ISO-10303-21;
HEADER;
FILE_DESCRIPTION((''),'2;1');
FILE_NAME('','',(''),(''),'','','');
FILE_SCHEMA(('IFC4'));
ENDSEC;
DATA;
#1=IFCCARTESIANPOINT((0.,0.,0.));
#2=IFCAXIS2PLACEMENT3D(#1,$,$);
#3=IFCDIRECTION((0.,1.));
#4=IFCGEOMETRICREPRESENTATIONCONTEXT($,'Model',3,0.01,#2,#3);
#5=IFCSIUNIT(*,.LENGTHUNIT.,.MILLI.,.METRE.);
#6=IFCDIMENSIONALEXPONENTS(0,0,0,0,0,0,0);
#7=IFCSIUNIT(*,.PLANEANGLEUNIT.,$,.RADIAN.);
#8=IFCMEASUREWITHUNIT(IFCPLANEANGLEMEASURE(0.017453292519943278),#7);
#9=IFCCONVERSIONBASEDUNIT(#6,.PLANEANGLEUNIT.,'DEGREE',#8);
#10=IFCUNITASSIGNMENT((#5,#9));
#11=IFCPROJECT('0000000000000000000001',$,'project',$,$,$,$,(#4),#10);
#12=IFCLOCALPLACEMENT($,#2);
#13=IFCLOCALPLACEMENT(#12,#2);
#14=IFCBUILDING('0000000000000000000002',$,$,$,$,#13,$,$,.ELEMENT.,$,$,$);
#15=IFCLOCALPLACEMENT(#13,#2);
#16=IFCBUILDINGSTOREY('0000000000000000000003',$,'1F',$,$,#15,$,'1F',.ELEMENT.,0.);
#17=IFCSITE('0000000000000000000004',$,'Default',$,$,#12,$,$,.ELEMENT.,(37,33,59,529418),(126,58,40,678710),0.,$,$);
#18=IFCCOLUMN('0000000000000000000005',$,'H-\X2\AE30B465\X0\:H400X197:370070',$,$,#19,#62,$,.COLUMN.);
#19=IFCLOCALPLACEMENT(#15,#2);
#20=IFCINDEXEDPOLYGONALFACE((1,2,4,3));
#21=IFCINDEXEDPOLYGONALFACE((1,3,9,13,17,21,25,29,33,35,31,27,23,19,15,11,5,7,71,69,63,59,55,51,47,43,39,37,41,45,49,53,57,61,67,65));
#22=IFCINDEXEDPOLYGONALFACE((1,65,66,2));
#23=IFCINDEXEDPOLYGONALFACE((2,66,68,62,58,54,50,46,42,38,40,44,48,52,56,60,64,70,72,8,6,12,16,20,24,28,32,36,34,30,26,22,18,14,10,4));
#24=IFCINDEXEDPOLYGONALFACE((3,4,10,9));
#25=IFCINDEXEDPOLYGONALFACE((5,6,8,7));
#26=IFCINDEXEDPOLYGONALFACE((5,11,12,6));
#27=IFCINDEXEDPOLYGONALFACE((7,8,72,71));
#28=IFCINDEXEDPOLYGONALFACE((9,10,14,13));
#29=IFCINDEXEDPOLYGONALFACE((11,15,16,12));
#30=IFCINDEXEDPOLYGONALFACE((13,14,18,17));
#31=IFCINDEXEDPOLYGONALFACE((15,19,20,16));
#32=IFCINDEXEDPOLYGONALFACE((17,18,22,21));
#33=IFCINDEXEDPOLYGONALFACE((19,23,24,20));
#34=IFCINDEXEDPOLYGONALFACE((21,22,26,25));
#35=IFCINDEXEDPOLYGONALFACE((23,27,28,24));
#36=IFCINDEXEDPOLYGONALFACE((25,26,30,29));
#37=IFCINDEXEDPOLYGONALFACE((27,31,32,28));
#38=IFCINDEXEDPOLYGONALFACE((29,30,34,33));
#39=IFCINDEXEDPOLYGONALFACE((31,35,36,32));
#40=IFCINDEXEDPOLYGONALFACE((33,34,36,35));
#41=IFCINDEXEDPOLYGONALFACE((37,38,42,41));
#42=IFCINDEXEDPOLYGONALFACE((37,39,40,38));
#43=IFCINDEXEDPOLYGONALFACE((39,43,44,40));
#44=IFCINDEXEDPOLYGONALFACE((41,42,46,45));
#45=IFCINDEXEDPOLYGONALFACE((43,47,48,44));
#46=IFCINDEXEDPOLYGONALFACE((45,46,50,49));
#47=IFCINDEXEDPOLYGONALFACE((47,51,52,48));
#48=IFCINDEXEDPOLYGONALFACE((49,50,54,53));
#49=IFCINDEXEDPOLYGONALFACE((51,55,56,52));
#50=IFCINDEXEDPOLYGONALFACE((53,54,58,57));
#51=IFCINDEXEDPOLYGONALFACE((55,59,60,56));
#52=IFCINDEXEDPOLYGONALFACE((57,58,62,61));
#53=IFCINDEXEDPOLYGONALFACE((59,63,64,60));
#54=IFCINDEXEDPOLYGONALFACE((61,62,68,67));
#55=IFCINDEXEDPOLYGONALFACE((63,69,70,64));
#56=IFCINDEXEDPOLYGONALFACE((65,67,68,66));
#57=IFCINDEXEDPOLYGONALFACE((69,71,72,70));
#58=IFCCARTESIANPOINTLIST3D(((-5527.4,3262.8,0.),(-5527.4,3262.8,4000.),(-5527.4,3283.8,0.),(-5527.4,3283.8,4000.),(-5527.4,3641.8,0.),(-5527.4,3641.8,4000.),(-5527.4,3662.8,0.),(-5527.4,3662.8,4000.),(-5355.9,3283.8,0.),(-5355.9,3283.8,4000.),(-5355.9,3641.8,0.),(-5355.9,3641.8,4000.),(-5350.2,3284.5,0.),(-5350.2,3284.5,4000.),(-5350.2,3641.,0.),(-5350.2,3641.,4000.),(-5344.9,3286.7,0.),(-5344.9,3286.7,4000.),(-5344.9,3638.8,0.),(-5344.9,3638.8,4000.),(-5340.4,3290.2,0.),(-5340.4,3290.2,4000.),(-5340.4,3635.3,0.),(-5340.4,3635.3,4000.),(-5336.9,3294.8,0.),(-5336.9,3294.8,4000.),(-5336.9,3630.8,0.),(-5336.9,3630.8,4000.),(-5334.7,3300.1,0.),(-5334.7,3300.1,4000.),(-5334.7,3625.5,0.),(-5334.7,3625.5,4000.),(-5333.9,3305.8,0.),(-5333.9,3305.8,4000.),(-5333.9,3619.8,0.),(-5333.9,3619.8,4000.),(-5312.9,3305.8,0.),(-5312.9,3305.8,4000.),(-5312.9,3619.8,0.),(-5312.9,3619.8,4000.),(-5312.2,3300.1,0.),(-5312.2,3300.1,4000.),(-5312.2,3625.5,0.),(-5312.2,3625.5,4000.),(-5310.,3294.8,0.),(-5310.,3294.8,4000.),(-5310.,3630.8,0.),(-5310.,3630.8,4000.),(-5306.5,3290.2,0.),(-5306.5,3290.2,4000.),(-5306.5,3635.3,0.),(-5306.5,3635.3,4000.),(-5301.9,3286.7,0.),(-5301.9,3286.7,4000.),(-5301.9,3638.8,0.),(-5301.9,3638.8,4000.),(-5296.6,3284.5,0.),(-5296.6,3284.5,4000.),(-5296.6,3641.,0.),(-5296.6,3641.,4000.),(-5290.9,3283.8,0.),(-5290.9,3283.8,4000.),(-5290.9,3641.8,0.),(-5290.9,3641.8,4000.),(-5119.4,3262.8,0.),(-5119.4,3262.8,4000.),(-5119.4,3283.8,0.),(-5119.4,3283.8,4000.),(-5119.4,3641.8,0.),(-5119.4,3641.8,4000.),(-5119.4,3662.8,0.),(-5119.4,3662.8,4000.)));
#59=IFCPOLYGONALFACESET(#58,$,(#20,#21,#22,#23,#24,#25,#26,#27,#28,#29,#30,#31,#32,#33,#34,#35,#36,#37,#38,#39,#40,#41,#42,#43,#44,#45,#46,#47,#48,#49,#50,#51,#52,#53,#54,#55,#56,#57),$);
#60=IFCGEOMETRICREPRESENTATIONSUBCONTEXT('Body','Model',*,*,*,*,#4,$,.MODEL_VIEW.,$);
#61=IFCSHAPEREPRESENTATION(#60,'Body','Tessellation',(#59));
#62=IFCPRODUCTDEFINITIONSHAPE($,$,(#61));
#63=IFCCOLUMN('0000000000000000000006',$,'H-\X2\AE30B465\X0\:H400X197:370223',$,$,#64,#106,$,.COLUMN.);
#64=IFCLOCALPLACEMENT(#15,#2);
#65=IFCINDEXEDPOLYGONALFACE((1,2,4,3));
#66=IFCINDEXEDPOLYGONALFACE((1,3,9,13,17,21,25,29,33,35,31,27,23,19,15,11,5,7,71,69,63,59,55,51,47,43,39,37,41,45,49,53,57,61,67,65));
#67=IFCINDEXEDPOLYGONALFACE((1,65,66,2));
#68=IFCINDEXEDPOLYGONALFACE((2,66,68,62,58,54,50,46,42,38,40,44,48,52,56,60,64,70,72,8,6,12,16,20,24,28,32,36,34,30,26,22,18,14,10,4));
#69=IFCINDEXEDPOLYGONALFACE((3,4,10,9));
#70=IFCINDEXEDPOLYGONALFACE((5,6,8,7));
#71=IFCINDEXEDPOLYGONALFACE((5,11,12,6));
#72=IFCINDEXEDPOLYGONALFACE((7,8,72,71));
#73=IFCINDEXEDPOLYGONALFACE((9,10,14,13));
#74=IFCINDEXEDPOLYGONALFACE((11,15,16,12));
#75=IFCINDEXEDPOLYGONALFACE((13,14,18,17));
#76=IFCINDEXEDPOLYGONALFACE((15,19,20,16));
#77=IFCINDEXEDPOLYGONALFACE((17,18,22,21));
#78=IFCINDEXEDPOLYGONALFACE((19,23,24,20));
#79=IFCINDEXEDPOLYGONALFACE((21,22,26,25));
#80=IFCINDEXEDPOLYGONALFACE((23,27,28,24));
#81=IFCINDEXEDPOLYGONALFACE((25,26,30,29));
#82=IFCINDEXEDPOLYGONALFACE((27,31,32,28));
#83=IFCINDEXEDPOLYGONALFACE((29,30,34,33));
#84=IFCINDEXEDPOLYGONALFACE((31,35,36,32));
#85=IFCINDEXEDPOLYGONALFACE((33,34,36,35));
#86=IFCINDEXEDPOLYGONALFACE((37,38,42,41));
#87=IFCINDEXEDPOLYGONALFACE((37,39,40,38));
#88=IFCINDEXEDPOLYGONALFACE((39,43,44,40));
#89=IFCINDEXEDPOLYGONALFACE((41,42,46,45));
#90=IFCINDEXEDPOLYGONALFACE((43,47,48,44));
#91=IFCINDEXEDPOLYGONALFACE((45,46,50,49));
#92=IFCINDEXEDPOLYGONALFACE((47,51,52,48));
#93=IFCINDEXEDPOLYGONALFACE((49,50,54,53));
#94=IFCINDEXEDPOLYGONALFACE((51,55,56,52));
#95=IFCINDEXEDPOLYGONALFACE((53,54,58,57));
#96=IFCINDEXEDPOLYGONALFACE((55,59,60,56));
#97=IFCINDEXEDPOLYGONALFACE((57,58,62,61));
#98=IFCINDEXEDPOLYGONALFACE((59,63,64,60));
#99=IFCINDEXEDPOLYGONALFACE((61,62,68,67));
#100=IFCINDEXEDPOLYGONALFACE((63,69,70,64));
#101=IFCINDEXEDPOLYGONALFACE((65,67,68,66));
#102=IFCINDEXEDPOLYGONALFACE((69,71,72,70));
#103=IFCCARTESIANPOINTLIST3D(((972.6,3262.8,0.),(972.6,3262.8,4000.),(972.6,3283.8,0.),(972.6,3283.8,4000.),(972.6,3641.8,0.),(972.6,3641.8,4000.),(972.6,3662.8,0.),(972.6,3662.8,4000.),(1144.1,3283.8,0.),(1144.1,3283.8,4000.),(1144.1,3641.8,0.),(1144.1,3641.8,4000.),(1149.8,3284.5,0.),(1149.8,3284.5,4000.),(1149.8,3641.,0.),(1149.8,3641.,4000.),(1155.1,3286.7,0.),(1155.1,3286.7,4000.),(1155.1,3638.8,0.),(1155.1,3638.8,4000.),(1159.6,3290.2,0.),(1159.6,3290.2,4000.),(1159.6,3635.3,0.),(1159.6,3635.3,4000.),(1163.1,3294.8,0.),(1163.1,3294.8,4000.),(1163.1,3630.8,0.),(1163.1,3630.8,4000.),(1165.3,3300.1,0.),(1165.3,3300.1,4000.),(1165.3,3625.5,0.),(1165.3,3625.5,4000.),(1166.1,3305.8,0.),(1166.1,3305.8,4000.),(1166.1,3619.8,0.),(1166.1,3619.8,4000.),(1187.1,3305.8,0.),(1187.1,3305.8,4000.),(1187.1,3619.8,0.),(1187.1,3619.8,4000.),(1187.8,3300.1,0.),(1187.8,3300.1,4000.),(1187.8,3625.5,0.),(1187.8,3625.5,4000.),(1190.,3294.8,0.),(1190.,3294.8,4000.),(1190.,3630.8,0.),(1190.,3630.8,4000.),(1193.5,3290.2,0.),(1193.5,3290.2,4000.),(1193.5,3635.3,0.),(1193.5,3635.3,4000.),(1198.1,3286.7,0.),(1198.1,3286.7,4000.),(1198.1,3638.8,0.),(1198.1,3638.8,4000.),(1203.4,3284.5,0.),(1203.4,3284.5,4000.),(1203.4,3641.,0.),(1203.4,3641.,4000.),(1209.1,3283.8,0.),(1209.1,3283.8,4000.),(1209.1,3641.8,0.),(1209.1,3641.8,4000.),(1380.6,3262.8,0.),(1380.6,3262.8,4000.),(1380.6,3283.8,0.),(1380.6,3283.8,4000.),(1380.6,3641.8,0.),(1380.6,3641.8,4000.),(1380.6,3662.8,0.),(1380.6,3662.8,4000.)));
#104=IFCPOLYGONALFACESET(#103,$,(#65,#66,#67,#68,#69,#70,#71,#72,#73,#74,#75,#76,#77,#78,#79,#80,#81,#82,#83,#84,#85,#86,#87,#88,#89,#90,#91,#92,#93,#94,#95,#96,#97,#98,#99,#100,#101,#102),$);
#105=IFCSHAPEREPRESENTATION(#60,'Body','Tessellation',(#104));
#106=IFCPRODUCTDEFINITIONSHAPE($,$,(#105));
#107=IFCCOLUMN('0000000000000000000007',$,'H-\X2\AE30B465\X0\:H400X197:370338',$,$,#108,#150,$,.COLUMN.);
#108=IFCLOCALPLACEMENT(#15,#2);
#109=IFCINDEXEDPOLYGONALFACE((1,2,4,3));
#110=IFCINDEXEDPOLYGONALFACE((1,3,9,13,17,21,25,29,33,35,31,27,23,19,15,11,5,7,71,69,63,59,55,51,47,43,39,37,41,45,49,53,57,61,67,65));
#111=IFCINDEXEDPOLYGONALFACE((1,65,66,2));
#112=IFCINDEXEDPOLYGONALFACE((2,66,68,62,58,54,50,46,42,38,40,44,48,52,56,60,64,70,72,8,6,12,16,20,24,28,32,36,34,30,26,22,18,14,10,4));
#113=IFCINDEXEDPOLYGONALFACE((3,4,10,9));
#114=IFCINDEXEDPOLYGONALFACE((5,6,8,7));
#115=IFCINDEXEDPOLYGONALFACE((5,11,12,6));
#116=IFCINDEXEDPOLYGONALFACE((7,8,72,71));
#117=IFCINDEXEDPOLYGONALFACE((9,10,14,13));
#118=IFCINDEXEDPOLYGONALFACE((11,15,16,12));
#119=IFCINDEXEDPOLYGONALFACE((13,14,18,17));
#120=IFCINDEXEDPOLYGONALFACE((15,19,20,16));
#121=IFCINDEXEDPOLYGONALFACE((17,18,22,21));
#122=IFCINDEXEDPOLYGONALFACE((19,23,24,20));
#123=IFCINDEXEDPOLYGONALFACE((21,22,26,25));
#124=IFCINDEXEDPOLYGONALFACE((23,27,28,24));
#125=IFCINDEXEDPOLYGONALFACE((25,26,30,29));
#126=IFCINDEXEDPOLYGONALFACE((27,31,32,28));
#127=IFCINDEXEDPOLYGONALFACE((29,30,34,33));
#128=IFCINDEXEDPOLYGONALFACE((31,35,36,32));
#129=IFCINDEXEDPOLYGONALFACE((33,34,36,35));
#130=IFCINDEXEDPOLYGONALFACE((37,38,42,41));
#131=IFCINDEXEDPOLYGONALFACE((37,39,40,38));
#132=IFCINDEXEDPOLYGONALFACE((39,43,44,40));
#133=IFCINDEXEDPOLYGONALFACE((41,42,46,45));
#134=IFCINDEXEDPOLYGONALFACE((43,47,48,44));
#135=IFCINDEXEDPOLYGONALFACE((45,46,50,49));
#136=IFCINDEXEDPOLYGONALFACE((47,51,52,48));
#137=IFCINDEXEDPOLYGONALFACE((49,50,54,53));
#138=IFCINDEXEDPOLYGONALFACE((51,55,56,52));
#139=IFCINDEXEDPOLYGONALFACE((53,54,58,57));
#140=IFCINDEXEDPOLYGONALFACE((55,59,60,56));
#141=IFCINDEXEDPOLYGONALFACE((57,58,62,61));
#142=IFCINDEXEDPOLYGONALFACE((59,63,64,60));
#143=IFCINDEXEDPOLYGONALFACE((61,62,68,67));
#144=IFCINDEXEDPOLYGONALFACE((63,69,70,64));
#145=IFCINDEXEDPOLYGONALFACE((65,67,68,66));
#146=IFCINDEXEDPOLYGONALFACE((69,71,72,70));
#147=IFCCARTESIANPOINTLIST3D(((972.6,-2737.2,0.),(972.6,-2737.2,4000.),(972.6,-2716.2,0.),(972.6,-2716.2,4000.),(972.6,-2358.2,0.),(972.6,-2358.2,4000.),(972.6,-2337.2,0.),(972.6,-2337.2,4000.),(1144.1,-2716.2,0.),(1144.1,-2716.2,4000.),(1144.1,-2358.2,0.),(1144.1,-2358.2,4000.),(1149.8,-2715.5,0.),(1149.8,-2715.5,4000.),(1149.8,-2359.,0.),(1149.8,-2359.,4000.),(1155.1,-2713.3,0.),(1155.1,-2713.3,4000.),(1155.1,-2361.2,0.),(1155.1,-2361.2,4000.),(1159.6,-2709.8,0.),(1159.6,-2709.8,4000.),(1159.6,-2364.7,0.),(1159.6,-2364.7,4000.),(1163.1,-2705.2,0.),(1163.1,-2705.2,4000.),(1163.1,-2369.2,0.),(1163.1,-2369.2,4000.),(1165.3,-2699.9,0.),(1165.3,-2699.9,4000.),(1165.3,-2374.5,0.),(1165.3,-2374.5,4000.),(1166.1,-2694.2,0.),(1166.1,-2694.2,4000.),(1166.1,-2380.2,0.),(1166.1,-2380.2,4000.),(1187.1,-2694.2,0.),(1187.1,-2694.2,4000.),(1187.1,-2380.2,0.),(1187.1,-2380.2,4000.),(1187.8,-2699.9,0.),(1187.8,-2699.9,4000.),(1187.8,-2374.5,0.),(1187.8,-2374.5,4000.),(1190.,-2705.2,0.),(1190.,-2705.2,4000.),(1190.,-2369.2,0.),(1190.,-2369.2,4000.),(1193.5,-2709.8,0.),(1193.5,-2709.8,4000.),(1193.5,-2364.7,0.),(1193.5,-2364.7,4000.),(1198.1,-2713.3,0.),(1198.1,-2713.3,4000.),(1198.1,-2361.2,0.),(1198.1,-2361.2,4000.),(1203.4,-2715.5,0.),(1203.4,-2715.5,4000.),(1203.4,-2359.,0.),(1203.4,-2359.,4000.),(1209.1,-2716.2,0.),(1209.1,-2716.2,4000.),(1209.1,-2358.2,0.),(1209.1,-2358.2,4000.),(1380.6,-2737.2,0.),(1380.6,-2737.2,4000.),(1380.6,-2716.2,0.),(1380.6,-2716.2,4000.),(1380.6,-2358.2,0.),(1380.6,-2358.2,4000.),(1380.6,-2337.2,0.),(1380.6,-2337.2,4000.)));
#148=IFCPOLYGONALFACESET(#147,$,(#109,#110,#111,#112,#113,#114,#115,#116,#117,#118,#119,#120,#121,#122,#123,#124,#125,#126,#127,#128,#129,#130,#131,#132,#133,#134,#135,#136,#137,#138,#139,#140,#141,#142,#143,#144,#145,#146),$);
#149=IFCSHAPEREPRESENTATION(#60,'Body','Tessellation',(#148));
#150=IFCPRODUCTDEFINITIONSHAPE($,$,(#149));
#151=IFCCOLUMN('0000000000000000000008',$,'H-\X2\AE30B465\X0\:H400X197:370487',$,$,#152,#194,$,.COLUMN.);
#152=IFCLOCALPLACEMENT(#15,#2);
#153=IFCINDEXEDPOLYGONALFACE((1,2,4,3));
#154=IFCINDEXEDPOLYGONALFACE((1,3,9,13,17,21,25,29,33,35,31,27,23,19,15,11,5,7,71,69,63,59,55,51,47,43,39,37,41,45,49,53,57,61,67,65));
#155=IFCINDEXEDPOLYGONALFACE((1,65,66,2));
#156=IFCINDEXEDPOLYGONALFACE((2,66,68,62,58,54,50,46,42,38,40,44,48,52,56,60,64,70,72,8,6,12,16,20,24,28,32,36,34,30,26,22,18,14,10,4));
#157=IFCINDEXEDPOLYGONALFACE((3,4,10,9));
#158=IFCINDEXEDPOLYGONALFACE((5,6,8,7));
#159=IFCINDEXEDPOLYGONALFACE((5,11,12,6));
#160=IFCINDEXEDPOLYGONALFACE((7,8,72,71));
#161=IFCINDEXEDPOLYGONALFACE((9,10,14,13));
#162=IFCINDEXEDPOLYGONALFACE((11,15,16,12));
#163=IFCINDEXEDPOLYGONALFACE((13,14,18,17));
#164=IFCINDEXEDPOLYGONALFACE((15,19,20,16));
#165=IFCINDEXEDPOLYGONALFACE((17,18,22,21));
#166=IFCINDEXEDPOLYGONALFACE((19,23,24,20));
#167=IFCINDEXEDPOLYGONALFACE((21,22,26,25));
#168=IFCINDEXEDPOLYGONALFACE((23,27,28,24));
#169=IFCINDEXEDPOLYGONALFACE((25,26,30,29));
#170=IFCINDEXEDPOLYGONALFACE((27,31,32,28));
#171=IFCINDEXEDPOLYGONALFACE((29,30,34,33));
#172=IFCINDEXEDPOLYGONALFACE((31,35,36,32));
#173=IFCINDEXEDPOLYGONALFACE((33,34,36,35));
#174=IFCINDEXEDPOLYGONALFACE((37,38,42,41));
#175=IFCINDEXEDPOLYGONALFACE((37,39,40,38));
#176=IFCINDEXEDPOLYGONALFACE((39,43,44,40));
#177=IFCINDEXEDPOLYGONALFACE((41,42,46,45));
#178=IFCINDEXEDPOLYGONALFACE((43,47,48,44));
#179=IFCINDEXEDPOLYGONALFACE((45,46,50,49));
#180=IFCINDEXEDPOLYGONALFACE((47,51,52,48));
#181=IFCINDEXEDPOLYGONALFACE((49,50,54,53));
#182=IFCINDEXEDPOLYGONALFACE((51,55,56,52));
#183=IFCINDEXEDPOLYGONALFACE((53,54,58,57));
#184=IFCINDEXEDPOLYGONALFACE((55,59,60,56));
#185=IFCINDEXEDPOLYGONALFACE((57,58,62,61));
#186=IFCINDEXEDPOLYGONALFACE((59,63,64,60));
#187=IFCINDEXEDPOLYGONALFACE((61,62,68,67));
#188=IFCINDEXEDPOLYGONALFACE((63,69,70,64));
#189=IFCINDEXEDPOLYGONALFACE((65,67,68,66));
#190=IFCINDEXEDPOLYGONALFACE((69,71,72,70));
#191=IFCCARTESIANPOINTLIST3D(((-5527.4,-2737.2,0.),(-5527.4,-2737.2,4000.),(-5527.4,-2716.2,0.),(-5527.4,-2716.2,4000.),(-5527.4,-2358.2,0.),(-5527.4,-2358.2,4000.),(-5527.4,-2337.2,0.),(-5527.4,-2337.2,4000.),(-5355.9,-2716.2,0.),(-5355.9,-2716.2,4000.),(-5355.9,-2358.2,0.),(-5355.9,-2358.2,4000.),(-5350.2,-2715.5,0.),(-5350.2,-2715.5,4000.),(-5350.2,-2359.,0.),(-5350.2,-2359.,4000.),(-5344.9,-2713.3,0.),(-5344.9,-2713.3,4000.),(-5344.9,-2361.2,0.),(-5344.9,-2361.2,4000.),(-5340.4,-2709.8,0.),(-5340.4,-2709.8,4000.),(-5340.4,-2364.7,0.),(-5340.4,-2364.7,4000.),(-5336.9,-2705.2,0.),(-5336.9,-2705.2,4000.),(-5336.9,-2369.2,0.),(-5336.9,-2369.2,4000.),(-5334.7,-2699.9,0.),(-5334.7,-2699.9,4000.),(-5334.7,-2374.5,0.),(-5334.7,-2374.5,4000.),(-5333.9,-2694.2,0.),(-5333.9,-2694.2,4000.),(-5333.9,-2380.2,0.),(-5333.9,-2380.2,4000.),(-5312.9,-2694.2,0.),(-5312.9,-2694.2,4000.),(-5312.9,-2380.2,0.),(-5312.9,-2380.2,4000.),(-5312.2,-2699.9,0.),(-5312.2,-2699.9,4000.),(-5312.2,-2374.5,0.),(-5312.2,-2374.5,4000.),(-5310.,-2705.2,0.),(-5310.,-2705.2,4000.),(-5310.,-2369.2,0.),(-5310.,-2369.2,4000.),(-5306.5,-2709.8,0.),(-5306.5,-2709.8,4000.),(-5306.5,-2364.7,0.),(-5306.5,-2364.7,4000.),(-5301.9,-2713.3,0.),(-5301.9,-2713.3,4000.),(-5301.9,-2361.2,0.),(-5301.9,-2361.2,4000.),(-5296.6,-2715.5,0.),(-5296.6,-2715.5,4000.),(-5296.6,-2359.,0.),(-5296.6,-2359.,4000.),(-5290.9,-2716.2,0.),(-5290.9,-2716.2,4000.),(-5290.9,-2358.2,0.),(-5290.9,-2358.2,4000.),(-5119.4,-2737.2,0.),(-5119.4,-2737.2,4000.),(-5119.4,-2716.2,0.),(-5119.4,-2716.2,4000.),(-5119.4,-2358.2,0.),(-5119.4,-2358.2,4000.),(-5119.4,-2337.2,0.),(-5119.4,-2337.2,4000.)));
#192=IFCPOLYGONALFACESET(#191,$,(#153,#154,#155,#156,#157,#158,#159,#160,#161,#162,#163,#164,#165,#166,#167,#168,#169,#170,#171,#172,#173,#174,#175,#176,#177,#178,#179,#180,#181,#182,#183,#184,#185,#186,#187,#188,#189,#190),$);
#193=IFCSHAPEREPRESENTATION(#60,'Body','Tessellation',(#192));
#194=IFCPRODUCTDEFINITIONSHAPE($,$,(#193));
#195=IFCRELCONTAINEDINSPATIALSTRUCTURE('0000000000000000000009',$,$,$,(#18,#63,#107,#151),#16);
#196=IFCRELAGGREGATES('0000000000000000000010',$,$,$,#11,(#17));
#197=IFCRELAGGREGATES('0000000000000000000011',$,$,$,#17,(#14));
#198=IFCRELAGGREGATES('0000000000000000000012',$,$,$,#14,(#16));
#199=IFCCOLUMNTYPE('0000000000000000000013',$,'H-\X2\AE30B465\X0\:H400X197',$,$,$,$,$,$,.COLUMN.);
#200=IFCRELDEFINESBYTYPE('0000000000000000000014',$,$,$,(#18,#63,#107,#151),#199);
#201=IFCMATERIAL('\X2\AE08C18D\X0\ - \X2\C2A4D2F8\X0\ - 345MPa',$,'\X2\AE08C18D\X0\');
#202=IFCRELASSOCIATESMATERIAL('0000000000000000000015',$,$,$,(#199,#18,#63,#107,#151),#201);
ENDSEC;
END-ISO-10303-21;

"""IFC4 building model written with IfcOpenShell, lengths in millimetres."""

from ifc_helpers import new_model, entity, si_unit, converted_unit, direction, frame, origin, place, context, subcontext, project, spatial, line, arc, indexed_curve, outline, extrude, source, transform, mapped, material, type_object, type_shapes, element, save


model = new_model("IFC4")

# Units and contexts
model_context = context("Model", 3, precision=0.01, world=origin(), true_north=direction((0.0, 1.0)))
body_context = subcontext(model_context, "Body", "Model", "MODEL_VIEW")
ifc_project = project(units=[si_unit("LENGTHUNIT", "METRE", prefix="MILLI"), converted_unit("PLANEANGLEUNIT", "DEGREE", entity("IfcPlaneAngleMeasure", 0.017453292519943278), si_unit("PLANEANGLEUNIT", "RADIAN"), dimensions=[0, 0, 0, 0, 0, 0, 0])], contexts=[model_context])

# Site, building, storey
site_placement = place(None, origin())
site = spatial("IfcSite", under=ifc_project, at=site_placement, Name="Default", CompositionType="ELEMENT", RefLatitude=(37, 33, 59, 529418), RefLongitude=(126, 58, 40, 678710), RefElevation=0.0)
building_placement = place(site_placement, origin())
building = spatial("IfcBuilding", under=site, at=building_placement, CompositionType="ELEMENT")
storey_placement = place(building_placement, origin())
storey = spatial("IfcBuildingStorey", under=building, at=storey_placement, Name="1F", LongName="1F", CompositionType="ELEMENT", Elevation=0.0)

# Columns
ifc_material = material(Name="금속 - 스틸 - 345MPa", Category="금속")
column_type = type_object("IfcColumnType", Name="H-기둥:H400X197", PredefinedType="COLUMN", material=ifc_material)
shared_shape = source(origin(), body_context, "Body", "SweptSolid", [
    extrude(outline(indexed_curve([(-204.0, -200.0), (204.0, -200.0), (204.0, -179.0), (32.5, -179.0), (16.9, -172.6), (10.5, -157.0), (10.5, 157.0), (16.9, 172.6), (32.5, 179.0), (204.0, 179.0), (204.0, 200.0), (-204.0, 200.0), (-204.0, 179.0), (-32.5, 179.0), (-16.9, 172.6), (-10.5, 157.0), (-10.5, -157.0), (-16.9, -172.6), (-32.5, -179.0), (-204.0, -179.0)], segments=[line(1, 2, 3, 4), arc(4, 5, 6), line(6, 7), arc(7, 8, 9), line(9, 10, 11, 12, 13, 14), arc(14, 15, 16), line(16, 17), arc(17, 18, 19), line(19, 20, 1)], self_intersect=False)), frame((0.0, 0.0, 0.0), z_axis=(0.0, 0.0, 1.0), x_axis=(-1.0, 0.0, 0.0)), (0.0, 0.0, 1.0), 4000.0),
])
type_shapes(column_type, [shared_shape])
for number, where, name in (
    (1, (-5323.4, 3462.8, 0.0), "H-기둥:H400X197:370070"),
    (2, (1176.6, 3462.8, 0.0), "H-기둥:H400X197:370223"),
    (3, (1176.6, -2537.2, 0.0), "H-기둥:H400X197:370338"),
    (4, (-5323.4, -2537.2, 0.0), "H-기둥:H400X197:370487"),
):
    element("IfcColumn", number, at=place(storey_placement, frame(where)), inside=storey, type_object=column_type, material=ifc_material, Name=name, PredefinedType="COLUMN", context=body_context, shape_type="MappedRepresentation", body=[
        mapped(shared_shape, transform((0.0, 0.0, 0.0), scale=1.0)),
    ])

save(model, "model.ifc")
